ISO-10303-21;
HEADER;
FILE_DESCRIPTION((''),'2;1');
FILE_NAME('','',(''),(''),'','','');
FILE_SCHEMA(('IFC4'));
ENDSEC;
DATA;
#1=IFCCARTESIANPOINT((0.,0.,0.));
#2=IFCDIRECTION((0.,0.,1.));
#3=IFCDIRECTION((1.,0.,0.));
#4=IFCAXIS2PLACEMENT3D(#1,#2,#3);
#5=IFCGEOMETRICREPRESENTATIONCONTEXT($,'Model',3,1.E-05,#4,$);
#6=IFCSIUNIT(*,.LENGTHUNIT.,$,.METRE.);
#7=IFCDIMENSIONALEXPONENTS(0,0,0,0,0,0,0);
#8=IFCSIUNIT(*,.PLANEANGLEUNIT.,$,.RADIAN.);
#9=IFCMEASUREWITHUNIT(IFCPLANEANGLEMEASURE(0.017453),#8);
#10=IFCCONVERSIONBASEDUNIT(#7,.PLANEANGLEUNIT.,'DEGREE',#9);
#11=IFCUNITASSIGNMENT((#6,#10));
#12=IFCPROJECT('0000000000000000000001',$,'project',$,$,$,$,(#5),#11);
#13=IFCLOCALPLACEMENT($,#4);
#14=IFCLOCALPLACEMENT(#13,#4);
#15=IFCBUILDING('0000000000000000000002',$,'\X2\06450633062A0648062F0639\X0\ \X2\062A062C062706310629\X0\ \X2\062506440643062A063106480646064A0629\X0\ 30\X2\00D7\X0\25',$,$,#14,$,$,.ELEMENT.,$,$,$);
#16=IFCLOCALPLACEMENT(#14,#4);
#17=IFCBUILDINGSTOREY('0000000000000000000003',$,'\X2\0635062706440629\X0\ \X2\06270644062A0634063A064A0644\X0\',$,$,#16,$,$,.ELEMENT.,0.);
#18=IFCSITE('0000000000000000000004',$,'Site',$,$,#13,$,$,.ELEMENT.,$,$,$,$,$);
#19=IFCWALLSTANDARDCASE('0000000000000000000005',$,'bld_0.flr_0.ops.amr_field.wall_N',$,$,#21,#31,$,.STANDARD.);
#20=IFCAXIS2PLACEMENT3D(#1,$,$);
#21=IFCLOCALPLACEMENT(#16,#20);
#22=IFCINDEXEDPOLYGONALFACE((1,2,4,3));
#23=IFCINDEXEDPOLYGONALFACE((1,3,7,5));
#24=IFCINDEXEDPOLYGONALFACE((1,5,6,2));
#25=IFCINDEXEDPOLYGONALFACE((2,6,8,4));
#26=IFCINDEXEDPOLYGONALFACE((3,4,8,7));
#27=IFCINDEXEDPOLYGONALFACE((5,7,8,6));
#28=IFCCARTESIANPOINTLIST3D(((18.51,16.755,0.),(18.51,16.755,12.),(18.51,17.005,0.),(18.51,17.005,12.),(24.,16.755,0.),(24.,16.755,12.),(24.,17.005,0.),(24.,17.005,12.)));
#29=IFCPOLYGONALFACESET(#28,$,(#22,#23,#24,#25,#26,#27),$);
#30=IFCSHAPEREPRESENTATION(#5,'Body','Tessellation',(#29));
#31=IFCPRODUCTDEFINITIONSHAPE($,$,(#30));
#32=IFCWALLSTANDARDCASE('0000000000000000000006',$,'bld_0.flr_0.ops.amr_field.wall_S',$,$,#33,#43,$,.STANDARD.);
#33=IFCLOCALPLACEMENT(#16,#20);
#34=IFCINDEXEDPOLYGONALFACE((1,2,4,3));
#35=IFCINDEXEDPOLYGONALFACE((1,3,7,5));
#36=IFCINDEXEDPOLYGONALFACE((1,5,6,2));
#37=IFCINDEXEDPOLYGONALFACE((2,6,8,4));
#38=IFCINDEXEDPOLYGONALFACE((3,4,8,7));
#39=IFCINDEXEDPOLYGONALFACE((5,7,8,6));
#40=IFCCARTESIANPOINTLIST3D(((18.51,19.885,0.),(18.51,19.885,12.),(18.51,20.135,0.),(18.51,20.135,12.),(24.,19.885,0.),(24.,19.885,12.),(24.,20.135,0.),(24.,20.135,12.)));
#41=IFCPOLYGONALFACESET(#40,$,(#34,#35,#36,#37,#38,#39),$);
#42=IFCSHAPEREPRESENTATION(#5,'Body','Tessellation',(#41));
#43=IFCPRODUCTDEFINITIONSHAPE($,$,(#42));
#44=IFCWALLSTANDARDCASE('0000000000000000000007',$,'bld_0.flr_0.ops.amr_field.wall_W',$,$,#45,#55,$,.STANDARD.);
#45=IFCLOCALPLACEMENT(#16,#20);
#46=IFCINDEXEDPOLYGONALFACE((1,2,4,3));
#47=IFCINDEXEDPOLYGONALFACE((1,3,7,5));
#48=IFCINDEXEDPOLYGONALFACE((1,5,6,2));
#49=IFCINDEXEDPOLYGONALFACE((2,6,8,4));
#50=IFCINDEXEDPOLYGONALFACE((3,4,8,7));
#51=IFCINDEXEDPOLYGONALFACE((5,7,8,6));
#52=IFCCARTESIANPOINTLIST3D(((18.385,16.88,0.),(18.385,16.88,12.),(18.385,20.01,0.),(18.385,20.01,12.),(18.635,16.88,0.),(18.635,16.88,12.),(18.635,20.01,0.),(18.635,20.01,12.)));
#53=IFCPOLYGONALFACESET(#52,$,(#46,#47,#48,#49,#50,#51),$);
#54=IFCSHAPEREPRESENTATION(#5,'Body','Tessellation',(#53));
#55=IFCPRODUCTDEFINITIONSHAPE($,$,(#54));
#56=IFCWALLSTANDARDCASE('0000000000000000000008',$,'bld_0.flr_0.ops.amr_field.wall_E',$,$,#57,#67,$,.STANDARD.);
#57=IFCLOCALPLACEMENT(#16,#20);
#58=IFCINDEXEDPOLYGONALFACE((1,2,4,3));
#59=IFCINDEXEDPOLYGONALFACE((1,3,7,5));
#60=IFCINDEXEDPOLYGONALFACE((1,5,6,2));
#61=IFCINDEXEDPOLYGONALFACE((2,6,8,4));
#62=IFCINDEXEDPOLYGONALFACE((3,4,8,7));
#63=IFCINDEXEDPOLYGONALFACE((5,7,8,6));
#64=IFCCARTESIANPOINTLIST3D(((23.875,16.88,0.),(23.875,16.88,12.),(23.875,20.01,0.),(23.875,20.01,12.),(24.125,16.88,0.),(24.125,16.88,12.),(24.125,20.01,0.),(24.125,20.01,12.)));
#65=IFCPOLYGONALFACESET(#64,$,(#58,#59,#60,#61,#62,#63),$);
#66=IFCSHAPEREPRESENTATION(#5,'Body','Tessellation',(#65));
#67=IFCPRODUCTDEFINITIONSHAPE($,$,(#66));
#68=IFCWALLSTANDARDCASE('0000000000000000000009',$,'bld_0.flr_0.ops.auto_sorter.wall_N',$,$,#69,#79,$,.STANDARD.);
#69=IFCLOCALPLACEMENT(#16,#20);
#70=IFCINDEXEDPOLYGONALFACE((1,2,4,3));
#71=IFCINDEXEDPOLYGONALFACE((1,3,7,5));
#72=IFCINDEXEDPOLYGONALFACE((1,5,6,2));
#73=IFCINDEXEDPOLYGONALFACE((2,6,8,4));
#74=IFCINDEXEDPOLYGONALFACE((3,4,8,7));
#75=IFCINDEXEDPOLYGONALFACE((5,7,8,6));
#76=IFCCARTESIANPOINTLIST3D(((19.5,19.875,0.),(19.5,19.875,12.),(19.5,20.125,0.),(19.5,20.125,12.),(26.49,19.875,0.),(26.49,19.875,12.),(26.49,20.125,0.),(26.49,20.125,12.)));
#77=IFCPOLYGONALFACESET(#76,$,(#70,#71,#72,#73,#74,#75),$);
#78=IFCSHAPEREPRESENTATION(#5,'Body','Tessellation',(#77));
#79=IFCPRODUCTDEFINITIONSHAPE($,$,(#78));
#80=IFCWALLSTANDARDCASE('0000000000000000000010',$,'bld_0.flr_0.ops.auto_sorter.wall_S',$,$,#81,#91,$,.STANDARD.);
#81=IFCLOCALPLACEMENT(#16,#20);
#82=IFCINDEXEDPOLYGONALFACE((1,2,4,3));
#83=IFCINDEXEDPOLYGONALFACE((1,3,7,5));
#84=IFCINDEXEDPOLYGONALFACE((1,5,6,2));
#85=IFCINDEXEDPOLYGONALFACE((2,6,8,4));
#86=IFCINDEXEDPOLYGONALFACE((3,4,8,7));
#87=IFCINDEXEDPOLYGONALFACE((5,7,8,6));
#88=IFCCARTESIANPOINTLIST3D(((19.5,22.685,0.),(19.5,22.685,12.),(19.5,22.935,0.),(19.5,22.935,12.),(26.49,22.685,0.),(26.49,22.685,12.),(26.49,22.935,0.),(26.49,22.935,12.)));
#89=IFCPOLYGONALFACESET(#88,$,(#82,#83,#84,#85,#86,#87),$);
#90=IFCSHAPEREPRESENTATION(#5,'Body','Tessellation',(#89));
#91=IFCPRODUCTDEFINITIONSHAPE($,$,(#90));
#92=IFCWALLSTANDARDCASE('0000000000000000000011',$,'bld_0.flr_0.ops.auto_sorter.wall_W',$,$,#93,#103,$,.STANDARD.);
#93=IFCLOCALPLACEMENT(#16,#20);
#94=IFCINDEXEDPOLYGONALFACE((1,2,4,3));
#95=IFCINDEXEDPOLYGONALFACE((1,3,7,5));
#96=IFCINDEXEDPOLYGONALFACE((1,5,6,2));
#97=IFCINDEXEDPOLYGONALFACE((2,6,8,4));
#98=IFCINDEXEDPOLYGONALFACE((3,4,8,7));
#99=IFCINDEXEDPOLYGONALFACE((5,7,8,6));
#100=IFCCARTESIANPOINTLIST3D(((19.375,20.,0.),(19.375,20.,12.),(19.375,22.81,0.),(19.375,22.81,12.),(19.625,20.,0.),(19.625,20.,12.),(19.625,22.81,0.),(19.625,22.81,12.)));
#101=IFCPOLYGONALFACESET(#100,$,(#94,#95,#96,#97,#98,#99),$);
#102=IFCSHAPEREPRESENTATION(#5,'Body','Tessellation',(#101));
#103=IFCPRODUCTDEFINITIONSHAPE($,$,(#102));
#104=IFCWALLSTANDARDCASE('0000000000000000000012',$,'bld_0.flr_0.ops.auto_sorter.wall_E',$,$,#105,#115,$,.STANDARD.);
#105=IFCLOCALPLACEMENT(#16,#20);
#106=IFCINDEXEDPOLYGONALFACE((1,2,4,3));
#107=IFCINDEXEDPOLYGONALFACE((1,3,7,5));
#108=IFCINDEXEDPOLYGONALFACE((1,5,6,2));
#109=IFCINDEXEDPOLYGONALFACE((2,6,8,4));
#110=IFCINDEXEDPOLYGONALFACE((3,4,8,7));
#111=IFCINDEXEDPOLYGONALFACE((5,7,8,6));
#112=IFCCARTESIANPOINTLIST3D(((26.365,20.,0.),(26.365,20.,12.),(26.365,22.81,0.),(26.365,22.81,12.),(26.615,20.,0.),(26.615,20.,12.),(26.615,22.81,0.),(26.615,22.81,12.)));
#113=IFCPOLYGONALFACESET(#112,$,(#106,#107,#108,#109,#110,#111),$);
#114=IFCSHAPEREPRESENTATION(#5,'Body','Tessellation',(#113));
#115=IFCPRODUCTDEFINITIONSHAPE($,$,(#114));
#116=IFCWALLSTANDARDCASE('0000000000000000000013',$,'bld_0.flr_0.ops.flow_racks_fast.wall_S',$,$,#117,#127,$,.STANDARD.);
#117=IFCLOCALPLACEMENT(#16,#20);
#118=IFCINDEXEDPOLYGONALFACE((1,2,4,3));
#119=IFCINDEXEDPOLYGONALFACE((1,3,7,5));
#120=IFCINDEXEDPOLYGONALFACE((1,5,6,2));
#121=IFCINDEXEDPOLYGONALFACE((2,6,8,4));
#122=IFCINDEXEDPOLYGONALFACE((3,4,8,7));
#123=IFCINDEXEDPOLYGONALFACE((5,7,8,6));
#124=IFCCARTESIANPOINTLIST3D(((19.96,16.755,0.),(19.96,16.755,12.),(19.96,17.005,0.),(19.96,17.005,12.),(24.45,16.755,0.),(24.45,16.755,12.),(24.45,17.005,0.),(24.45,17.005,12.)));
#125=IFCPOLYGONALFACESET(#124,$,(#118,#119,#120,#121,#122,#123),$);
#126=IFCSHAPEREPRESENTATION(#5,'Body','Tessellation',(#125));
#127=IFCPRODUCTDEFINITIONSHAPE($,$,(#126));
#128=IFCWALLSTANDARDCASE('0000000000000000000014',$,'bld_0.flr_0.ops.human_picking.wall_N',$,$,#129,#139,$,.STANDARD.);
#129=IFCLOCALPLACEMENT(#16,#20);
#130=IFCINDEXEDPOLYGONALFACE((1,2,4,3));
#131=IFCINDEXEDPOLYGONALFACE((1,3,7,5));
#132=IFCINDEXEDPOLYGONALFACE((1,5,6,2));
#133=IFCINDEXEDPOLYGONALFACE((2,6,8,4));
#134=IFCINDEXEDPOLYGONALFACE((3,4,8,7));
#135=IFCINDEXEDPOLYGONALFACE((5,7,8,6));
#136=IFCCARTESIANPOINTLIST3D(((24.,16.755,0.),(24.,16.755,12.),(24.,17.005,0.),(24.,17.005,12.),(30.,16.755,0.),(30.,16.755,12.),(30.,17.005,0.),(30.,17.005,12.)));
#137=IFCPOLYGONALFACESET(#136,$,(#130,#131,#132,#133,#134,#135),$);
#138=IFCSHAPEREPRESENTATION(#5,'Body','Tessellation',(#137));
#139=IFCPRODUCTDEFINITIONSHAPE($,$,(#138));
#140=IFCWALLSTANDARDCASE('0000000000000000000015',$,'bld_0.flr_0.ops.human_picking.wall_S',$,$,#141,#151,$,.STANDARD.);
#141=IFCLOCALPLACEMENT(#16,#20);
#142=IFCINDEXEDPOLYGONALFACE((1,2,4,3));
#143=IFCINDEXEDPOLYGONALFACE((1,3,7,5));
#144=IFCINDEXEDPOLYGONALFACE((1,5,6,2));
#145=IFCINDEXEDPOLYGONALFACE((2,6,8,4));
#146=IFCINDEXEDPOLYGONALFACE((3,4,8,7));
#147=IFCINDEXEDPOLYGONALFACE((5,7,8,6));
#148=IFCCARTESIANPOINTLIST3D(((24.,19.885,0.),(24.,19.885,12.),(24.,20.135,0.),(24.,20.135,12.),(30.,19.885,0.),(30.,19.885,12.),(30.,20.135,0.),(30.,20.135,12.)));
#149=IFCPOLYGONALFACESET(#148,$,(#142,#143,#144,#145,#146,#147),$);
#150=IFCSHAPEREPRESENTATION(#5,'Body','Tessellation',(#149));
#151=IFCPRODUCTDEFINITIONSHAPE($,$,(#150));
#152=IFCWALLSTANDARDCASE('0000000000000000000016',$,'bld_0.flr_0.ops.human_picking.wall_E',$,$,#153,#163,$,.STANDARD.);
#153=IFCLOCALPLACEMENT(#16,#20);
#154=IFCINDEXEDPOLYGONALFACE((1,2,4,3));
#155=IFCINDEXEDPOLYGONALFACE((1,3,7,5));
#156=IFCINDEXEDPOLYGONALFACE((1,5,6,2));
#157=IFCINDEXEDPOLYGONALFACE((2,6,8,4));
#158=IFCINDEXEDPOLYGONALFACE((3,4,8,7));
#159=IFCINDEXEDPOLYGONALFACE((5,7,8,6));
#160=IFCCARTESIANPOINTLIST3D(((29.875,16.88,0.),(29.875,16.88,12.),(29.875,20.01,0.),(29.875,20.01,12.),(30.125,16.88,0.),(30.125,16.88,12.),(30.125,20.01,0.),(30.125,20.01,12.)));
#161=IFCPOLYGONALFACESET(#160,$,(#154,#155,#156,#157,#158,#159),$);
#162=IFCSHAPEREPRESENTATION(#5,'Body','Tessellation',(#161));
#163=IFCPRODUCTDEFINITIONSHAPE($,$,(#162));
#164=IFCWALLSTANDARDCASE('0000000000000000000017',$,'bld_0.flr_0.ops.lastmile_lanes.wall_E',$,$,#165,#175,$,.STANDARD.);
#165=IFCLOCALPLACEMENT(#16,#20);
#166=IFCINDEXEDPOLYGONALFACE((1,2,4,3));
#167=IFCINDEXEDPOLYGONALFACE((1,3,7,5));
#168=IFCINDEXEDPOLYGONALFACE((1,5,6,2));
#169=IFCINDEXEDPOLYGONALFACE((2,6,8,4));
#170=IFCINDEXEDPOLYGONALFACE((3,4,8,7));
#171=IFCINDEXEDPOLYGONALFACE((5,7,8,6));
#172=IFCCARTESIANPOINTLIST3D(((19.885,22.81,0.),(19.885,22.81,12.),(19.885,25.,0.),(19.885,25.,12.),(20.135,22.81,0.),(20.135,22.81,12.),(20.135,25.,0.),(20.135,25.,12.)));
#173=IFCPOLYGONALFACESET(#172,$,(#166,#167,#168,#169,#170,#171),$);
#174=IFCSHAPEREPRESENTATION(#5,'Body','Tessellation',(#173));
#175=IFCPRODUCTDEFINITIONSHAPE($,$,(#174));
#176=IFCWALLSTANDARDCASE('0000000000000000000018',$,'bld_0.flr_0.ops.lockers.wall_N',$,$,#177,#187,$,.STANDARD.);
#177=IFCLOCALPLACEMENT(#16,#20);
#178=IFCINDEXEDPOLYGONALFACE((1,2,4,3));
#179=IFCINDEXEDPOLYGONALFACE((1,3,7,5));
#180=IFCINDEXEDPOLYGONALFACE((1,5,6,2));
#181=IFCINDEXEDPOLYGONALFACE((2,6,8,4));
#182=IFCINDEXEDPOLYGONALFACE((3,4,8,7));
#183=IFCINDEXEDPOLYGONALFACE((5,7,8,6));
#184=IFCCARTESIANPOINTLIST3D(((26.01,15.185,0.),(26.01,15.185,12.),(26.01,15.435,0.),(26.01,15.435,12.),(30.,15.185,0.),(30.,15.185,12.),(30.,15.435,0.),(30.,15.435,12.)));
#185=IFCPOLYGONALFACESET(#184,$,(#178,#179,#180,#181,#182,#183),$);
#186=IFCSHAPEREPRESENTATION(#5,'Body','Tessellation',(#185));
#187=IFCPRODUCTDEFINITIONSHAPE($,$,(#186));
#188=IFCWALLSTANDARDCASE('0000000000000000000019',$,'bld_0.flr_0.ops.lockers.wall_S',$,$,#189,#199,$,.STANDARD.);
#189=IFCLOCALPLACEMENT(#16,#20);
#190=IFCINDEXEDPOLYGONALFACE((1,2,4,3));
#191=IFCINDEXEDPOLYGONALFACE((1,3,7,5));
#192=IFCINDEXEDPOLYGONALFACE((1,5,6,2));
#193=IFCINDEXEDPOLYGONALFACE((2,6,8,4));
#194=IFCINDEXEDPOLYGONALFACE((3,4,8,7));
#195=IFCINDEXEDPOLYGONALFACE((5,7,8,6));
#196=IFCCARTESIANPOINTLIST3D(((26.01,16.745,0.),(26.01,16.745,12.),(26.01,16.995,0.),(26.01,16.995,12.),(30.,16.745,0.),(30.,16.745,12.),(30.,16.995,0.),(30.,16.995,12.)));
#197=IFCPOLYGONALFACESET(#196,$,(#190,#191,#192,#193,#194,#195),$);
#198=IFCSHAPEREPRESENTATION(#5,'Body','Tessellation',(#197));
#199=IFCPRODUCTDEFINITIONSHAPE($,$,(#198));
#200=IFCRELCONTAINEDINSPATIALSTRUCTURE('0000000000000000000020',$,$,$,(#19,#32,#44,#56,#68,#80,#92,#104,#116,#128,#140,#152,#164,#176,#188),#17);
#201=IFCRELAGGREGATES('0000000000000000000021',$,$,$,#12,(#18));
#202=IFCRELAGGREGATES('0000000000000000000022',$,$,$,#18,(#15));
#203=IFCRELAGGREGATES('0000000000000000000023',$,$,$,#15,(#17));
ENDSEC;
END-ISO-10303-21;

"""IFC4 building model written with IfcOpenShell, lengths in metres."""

from ifc_helpers import new_model, entity, si_unit, converted_unit, frame, frame_2d, origin_with_axes, place, context, project, spatial, rectangle, extrude, element, save


model = new_model("IFC4")

# Units and contexts
model_context = context("Model", 3, precision=1e-05, world=origin_with_axes())
ifc_project = project(units=[si_unit("LENGTHUNIT", "METRE"), converted_unit("PLANEANGLEUNIT", "DEGREE", entity("IfcPlaneAngleMeasure", 0.017453), si_unit("PLANEANGLEUNIT", "RADIAN"), dimensions=[0, 0, 0, 0, 0, 0, 0])], contexts=[model_context])

# Site, building, storey
site_placement = place(None, origin_with_axes())
site = spatial("IfcSite", under=ifc_project, at=site_placement, Name="Site", CompositionType="ELEMENT")
building_placement = place(site_placement, origin_with_axes())
building = spatial("IfcBuilding", under=site, at=building_placement, Name="مستودع تجارة إلكترونية 30×25", CompositionType="ELEMENT")
storey_placement = place(building_placement, origin_with_axes())
storey = spatial("IfcBuildingStorey", under=building, at=storey_placement, Name="صالة التشغيل", CompositionType="ELEMENT", Elevation=0.0)

# Walls
for number, where, z_axis, x_axis, name in (
    (1, (18.51, 16.88, 0.0), (0.0, 0.0, 1.0), (1.0, 0.0, 0.0), "bld_0.flr_0.ops.amr_field.wall_N"),
    (2, (18.51, 20.01, 0.0), (0.0, 0.0, 1.0), (1.0, 0.0, 0.0), "bld_0.flr_0.ops.amr_field.wall_S"),
):
    element("IfcWallStandardCase", number, at=place(storey_placement, frame(where, z_axis=z_axis, x_axis=x_axis)), inside=storey, Name=name, PredefinedType="STANDARD", context=model_context, shape_type="SweptSolid", body=[
        extrude(rectangle(XDim=5.49, YDim=0.25, at=frame_2d((2.745, 0.0), x_axis=(1.0, 0.0))), origin_with_axes(), (0.0, 0.0, 1.0), 12.0),
    ])
for number, where, z_axis, x_axis, name in (
    (3, (18.51, 16.88, 0.0), (0.0, 0.0, 1.0), (0.0, 1.0, 0.0), "bld_0.flr_0.ops.amr_field.wall_W"),
    (4, (24.0, 16.88, 0.0), (0.0, 0.0, 1.0), (0.0, 1.0, 0.0), "bld_0.flr_0.ops.amr_field.wall_E"),
):
    element("IfcWallStandardCase", number, at=place(storey_placement, frame(where, z_axis=z_axis, x_axis=x_axis)), inside=storey, Name=name, PredefinedType="STANDARD", context=model_context, shape_type="SweptSolid", body=[
        extrude(rectangle(XDim=3.13, YDim=0.25, at=frame_2d((1.565, 0.0), x_axis=(1.0, 0.0))), origin_with_axes(), (0.0, 0.0, 1.0), 12.0),
    ])
for number, where, z_axis, x_axis, name in (
    (5, (19.5, 20.0, 0.0), (0.0, 0.0, 1.0), (1.0, 0.0, 0.0), "bld_0.flr_0.ops.auto_sorter.wall_N"),
    (6, (19.5, 22.81, 0.0), (0.0, 0.0, 1.0), (1.0, 0.0, 0.0), "bld_0.flr_0.ops.auto_sorter.wall_S"),
):
    element("IfcWallStandardCase", number, at=place(storey_placement, frame(where, z_axis=z_axis, x_axis=x_axis)), inside=storey, Name=name, PredefinedType="STANDARD", context=model_context, shape_type="SweptSolid", body=[
        extrude(rectangle(XDim=6.99, YDim=0.25, at=frame_2d((3.495, 0.0), x_axis=(1.0, 0.0))), origin_with_axes(), (0.0, 0.0, 1.0), 12.0),
    ])
for number, where, z_axis, x_axis, name in (
    (7, (19.5, 20.0, 0.0), (0.0, 0.0, 1.0), (0.0, 1.0, 0.0), "bld_0.flr_0.ops.auto_sorter.wall_W"),
    (8, (26.49, 20.0, 0.0), (0.0, 0.0, 1.0), (0.0, 1.0, 0.0), "bld_0.flr_0.ops.auto_sorter.wall_E"),
):
    element("IfcWallStandardCase", number, at=place(storey_placement, frame(where, z_axis=z_axis, x_axis=x_axis)), inside=storey, Name=name, PredefinedType="STANDARD", context=model_context, shape_type="SweptSolid", body=[
        extrude(rectangle(XDim=2.81, YDim=0.25, at=frame_2d((1.405, 0.0), x_axis=(1.0, 0.0))), origin_with_axes(), (0.0, 0.0, 1.0), 12.0),
    ])
wall_1_placement = place(storey_placement, frame((19.96, 16.88, 0.0), z_axis=(0.0, 0.0, 1.0), x_axis=(1.0, 0.0, 0.0)))
element("IfcWallStandardCase", 9, at=wall_1_placement, inside=storey, Name="bld_0.flr_0.ops.flow_racks_fast.wall_S", PredefinedType="STANDARD", context=model_context, shape_type="SweptSolid", body=[
    extrude(rectangle(XDim=4.49, YDim=0.25, at=frame_2d((2.245, 0.0), x_axis=(1.0, 0.0))), origin_with_axes(), (0.0, 0.0, 1.0), 12.0),
])
for number, where, z_axis, x_axis, name in (
    (10, (24.0, 16.88, 0.0), (0.0, 0.0, 1.0), (1.0, 0.0, 0.0), "bld_0.flr_0.ops.human_picking.wall_N"),
    (11, (24.0, 20.01, 0.0), (0.0, 0.0, 1.0), (1.0, 0.0, 0.0), "bld_0.flr_0.ops.human_picking.wall_S"),
):
    element("IfcWallStandardCase", number, at=place(storey_placement, frame(where, z_axis=z_axis, x_axis=x_axis)), inside=storey, Name=name, PredefinedType="STANDARD", context=model_context, shape_type="SweptSolid", body=[
        extrude(rectangle(XDim=6.0, YDim=0.25, at=frame_2d((3.0, 0.0), x_axis=(1.0, 0.0))), origin_with_axes(), (0.0, 0.0, 1.0), 12.0),
    ])
for number, where, z_axis, x_axis, name in (
    (12, (30.0, 16.88, 0.0), (0.0, 0.0, 1.0), (0.0, 1.0, 0.0), "bld_0.flr_0.ops.human_picking.wall_E"),
):
    element("IfcWallStandardCase", number, at=place(storey_placement, frame(where, z_axis=z_axis, x_axis=x_axis)), inside=storey, Name=name, PredefinedType="STANDARD", context=model_context, shape_type="SweptSolid", body=[
        extrude(rectangle(XDim=3.13, YDim=0.25, at=frame_2d((1.565, 0.0), x_axis=(1.0, 0.0))), origin_with_axes(), (0.0, 0.0, 1.0), 12.0),
    ])
wall_2_placement = place(storey_placement, frame((20.01, 22.81, 0.0), z_axis=(0.0, 0.0, 1.0), x_axis=(0.0, 1.0, 0.0)))
element("IfcWallStandardCase", 13, at=wall_2_placement, inside=storey, Name="bld_0.flr_0.ops.lastmile_lanes.wall_E", PredefinedType="STANDARD", context=model_context, shape_type="SweptSolid", body=[
    extrude(rectangle(XDim=2.19, YDim=0.25, at=frame_2d((1.095, 0.0), x_axis=(1.0, 0.0))), origin_with_axes(), (0.0, 0.0, 1.0), 12.0),
])
for number, where, z_axis, x_axis, name in (
    (14, (26.01, 15.31, 0.0), (0.0, 0.0, 1.0), (1.0, 0.0, 0.0), "bld_0.flr_0.ops.lockers.wall_N"),
    (15, (26.01, 16.87, 0.0), (0.0, 0.0, 1.0), (1.0, 0.0, 0.0), "bld_0.flr_0.ops.lockers.wall_S"),
):
    element("IfcWallStandardCase", number, at=place(storey_placement, frame(where, z_axis=z_axis, x_axis=x_axis)), inside=storey, Name=name, PredefinedType="STANDARD", context=model_context, shape_type="SweptSolid", body=[
        extrude(rectangle(XDim=3.99, YDim=0.25, at=frame_2d((1.995, 0.0), x_axis=(1.0, 0.0))), origin_with_axes(), (0.0, 0.0, 1.0), 12.0),
    ])

save(model, "model.ifc")
